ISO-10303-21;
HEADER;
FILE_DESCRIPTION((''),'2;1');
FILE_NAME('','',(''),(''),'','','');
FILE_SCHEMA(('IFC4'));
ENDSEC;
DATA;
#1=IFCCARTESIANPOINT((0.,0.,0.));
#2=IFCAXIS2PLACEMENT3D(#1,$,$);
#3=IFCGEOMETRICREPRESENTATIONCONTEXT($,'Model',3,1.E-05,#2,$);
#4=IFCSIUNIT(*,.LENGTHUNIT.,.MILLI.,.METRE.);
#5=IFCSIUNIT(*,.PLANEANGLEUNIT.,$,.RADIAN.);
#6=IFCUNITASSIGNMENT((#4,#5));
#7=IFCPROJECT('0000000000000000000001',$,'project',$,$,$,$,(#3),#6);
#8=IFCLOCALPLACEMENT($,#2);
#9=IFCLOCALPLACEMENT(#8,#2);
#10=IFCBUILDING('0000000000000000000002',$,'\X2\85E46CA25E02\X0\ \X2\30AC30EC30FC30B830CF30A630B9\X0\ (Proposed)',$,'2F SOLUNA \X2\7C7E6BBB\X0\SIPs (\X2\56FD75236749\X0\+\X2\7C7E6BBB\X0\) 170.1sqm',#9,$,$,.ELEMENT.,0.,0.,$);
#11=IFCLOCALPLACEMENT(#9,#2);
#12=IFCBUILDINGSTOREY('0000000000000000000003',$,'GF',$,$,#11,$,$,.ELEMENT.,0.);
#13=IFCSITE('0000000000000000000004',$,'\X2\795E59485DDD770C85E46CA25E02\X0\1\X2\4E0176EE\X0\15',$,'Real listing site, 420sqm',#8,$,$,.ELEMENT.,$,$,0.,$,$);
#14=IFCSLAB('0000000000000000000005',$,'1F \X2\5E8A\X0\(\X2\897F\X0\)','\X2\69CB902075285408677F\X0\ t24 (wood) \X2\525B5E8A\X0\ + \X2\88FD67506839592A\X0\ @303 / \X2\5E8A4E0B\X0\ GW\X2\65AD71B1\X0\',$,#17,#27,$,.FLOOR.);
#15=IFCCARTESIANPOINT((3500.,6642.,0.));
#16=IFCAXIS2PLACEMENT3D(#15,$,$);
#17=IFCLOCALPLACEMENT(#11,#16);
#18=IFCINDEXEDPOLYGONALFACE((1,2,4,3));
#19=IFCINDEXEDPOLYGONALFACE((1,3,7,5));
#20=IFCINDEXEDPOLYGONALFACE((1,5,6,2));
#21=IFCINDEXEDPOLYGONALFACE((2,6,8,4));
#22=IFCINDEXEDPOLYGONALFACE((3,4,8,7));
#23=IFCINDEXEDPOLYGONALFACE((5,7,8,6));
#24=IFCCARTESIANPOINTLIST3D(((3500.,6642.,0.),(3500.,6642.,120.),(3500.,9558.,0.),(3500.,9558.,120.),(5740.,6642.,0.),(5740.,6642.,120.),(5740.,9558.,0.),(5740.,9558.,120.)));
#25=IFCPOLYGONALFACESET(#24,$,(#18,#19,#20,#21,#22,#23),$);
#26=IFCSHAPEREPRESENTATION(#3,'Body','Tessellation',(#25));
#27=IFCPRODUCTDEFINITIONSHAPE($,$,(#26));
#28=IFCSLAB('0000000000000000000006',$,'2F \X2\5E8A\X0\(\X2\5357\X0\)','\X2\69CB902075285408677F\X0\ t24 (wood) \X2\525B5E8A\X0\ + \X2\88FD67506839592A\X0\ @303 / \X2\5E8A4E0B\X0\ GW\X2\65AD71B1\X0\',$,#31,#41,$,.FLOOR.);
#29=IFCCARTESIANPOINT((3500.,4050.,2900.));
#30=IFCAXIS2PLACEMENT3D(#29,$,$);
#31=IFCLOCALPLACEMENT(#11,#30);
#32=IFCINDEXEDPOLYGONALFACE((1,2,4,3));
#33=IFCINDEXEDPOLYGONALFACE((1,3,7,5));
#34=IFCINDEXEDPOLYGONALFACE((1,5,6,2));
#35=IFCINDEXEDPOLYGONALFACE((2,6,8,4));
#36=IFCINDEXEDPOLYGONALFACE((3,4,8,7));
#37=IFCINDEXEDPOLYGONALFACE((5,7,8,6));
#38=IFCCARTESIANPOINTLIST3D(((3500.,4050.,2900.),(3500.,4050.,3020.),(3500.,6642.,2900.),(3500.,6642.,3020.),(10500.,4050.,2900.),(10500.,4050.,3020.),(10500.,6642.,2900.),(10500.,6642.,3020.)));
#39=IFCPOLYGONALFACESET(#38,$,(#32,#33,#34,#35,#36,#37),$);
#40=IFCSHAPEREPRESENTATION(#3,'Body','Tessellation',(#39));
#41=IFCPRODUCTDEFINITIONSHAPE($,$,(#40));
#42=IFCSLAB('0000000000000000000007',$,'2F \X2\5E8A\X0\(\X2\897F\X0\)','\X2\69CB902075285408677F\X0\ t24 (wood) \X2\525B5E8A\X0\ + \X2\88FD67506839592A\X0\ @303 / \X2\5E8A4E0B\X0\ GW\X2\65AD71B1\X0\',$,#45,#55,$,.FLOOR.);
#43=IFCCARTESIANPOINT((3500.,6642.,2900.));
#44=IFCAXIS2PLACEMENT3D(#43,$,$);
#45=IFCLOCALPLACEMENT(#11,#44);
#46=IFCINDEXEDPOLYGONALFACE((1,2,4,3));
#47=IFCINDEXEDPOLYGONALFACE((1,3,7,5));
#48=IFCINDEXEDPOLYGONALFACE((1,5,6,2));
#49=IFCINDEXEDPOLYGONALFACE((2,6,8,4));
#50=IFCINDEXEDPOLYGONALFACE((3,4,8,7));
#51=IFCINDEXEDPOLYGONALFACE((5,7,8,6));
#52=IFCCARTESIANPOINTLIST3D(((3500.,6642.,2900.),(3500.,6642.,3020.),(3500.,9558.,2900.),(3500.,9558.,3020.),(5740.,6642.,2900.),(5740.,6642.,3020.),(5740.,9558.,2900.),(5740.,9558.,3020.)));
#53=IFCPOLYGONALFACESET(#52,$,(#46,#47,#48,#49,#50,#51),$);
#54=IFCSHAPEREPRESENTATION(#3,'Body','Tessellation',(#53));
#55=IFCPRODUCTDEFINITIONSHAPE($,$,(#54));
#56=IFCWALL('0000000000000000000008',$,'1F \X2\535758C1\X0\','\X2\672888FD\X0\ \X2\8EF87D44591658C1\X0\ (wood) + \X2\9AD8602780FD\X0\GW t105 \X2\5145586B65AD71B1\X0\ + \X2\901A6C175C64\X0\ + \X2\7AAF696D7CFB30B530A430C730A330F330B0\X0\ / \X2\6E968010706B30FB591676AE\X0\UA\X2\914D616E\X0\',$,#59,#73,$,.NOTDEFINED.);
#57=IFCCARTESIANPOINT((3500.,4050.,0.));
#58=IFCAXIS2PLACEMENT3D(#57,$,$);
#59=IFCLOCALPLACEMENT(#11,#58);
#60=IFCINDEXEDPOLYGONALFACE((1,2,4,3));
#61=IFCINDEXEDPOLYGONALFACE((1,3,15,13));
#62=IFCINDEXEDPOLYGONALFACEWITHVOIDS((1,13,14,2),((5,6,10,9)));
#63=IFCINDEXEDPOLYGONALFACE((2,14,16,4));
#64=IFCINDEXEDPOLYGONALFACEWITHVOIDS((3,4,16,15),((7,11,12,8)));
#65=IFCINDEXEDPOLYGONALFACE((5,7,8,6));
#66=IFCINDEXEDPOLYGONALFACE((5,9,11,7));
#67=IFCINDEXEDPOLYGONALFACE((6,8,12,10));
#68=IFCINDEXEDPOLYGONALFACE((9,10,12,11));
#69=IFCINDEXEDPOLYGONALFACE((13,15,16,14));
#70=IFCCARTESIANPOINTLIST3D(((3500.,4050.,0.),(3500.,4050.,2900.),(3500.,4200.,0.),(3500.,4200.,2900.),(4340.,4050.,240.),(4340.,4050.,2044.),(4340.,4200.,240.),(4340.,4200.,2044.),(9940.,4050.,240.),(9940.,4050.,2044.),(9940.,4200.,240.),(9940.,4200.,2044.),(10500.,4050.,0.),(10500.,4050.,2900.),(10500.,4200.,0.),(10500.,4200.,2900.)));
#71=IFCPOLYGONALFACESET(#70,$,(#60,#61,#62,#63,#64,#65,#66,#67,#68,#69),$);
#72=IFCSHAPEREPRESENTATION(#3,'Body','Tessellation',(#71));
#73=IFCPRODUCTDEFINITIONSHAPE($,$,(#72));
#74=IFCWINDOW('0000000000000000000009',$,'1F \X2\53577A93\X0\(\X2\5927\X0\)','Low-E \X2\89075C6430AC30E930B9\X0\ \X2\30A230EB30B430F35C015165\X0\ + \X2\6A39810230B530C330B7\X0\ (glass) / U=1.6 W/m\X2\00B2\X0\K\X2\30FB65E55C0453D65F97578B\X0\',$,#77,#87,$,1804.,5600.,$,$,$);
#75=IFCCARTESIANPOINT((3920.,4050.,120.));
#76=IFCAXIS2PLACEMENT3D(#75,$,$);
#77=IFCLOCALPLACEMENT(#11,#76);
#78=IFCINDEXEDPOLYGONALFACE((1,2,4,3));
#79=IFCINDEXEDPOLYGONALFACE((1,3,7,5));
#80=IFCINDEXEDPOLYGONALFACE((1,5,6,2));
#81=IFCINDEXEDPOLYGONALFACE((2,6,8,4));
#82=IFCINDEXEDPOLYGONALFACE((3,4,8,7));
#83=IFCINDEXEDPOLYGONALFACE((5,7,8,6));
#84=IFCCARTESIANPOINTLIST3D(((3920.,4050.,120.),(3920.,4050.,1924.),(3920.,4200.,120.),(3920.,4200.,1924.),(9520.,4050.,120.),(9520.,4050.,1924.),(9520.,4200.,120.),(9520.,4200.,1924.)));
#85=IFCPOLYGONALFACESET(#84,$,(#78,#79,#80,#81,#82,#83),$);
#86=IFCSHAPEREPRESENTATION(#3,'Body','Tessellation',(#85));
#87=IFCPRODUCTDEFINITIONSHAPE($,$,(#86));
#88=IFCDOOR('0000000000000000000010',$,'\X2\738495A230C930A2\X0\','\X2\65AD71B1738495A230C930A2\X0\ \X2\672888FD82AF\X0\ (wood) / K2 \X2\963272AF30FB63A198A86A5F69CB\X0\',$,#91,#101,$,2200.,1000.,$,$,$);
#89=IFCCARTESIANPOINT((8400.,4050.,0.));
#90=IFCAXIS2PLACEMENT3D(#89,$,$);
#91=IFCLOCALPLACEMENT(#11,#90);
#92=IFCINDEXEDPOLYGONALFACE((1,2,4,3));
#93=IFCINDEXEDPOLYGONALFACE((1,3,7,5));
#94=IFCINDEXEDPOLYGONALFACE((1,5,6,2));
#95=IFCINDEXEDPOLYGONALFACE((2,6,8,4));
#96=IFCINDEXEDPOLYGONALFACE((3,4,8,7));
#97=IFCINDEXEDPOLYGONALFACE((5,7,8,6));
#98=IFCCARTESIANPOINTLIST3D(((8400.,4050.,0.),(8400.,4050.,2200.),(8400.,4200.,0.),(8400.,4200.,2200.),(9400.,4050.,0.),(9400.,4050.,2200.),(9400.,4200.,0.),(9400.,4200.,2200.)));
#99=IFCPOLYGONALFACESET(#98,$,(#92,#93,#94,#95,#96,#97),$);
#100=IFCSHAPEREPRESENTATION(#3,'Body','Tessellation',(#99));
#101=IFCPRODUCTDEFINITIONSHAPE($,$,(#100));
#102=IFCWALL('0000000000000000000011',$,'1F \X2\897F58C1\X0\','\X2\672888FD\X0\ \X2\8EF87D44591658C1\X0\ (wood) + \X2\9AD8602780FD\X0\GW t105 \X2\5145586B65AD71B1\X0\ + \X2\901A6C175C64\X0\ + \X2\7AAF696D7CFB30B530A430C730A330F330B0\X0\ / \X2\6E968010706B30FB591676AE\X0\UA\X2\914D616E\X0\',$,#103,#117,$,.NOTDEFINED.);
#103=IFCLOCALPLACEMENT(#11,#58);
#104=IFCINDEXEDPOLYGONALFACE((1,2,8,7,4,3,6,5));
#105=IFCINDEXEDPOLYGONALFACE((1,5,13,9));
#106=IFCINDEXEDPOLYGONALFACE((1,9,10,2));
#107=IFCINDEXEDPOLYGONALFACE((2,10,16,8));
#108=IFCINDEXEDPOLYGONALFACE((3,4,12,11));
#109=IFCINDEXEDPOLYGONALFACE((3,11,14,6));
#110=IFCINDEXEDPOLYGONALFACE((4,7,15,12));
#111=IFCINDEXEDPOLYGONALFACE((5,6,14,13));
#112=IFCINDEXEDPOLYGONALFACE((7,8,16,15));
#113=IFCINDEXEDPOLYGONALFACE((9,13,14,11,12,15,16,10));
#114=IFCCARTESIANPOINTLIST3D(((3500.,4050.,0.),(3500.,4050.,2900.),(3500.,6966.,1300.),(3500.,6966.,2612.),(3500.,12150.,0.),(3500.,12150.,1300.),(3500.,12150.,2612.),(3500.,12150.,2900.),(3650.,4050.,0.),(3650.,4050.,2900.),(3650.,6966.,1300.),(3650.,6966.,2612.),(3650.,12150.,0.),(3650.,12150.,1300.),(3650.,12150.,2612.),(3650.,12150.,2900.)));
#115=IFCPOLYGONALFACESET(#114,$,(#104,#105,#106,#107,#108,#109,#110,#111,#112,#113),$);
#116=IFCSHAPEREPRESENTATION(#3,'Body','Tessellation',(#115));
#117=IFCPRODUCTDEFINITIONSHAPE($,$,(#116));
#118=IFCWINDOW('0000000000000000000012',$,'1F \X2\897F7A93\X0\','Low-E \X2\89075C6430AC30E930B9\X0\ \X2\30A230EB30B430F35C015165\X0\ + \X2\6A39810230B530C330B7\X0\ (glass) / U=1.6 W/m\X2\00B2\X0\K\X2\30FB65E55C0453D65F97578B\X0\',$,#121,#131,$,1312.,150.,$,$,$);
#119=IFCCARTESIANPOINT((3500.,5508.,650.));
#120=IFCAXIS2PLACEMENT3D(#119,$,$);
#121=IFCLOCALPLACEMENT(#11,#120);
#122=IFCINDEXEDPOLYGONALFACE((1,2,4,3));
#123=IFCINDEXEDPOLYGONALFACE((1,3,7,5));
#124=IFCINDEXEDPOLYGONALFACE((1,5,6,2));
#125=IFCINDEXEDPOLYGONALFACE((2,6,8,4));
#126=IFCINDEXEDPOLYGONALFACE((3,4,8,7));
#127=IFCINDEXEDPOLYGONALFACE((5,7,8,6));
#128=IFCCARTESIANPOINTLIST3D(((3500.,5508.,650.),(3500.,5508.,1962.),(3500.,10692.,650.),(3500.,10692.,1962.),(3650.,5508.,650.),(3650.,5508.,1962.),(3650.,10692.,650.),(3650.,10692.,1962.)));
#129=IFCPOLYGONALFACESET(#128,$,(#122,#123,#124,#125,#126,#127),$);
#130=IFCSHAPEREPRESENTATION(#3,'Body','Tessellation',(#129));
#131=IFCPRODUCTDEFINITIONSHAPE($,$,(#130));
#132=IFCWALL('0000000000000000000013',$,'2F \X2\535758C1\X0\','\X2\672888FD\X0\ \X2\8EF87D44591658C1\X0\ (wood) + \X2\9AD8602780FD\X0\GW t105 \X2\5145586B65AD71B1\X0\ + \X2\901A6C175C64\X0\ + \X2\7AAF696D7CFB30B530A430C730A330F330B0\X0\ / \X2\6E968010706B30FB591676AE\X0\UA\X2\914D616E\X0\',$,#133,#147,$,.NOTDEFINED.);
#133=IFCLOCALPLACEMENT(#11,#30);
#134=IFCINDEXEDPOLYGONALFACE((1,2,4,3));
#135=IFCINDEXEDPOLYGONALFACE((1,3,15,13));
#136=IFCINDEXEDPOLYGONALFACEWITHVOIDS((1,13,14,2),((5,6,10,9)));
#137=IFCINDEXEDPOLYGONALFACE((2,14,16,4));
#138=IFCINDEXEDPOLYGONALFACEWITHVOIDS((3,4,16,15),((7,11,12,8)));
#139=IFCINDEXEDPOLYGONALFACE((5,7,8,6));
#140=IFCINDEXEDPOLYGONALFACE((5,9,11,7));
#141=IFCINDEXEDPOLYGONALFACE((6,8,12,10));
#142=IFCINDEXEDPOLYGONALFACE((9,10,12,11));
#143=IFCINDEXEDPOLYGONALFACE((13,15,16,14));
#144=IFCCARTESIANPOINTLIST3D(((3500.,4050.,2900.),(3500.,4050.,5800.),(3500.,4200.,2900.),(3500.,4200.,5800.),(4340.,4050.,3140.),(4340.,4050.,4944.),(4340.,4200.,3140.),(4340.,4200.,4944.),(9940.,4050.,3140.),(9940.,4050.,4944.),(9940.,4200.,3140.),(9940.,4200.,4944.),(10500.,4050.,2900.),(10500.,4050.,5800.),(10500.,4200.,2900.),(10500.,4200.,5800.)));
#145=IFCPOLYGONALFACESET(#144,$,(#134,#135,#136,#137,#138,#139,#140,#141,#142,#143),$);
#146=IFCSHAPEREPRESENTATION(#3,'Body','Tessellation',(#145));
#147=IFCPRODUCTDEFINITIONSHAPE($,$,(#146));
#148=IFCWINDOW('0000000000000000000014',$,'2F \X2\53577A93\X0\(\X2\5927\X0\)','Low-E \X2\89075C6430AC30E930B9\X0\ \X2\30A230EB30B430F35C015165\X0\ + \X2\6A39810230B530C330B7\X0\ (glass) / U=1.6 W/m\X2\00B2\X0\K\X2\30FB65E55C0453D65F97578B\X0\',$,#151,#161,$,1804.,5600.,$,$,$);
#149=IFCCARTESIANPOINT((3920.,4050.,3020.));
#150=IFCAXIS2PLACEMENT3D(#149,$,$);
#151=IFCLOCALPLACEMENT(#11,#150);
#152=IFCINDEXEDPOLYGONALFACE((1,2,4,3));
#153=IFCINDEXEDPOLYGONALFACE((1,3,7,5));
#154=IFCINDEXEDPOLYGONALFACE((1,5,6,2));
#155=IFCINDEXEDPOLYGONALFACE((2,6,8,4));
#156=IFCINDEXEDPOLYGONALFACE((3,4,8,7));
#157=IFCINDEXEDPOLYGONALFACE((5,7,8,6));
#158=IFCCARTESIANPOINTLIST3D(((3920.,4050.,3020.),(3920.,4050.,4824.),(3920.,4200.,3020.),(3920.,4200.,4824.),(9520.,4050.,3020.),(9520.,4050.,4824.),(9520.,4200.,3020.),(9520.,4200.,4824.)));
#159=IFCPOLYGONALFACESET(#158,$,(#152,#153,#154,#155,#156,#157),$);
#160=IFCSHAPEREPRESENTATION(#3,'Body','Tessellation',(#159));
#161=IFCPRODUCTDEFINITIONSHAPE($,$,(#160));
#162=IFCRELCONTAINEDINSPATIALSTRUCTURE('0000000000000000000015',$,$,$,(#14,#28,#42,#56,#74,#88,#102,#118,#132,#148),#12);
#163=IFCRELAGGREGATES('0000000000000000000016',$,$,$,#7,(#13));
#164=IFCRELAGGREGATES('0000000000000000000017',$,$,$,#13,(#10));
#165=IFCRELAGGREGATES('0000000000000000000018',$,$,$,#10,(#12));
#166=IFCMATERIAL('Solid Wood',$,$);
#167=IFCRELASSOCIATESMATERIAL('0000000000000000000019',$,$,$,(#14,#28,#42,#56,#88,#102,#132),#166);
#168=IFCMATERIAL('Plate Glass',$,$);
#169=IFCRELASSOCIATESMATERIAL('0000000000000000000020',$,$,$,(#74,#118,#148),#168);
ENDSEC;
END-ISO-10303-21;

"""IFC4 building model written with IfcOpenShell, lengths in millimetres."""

from ifc_helpers import new_model, si_unit, frame, frame_2d, origin, place, context, project, spatial, rectangle, extrude, material, element, fill, save


model = new_model("IFC4")

# Units and contexts
model_context = context("Model", 3, precision=1e-05, world=origin())
ifc_project = project(units=[si_unit("LENGTHUNIT", "METRE", prefix="MILLI"), si_unit("PLANEANGLEUNIT", "RADIAN")], contexts=[model_context])

# Site, building, storey
site_placement = place(None, origin())
site = spatial("IfcSite", under=ifc_project, at=site_placement, Name="神奈川県藤沢市1丁目15", ObjectType="Real listing site, 420sqm", CompositionType="ELEMENT", RefElevation=0.0)
building_placement = place(site_placement, origin())
building = spatial("IfcBuilding", under=site, at=building_placement, Name="藤沢市 ガレージハウス (Proposed)", ObjectType="2F SOLUNA 籾殻SIPs (国産杉+籾殻) 170.1sqm", CompositionType="ELEMENT", ElevationOfRefHeight=0.0, ElevationOfTerrain=0.0)
storey_placement = place(building_placement, origin())
storey = spatial("IfcBuildingStorey", under=building, at=storey_placement, Name="GF", CompositionType="ELEMENT", Elevation=0.0)

# Slabs
ifc_material_1 = material(Name="Solid Wood")
slab_1_placement = place(storey_placement, frame((3500.0, 6642.0, 0.0)))
element("IfcSlab", 1, at=slab_1_placement, inside=storey, material=ifc_material_1, Name="1F 床(西)", Description="構造用合板 t24 (wood) 剛床 + 製材根太 @303 / 床下 GW断熱", PredefinedType="FLOOR", context=model_context, shape_type="SweptSolid", body=[
    extrude(rectangle(XDim=2240.0, YDim=2916.0, at=frame_2d((1120.0, 1458.0))), frame((3500.0, 6642.0, 0.0)), (0.0, 0.0, 1.0), 120.0),
])
slab_2_placement = place(storey_placement, frame((3500.0, 4050.0, 2900.0)))
element("IfcSlab", 2, at=slab_2_placement, inside=storey, material=ifc_material_1, Name="2F 床(南)", Description="構造用合板 t24 (wood) 剛床 + 製材根太 @303 / 床下 GW断熱", PredefinedType="FLOOR", context=model_context, shape_type="SweptSolid", body=[
    extrude(rectangle(XDim=7000.0, YDim=2592.0, at=frame_2d((3500.0, 1296.0))), frame((3500.0, 4050.0, 2900.0)), (0.0, 0.0, 1.0), 120.0),
])
slab_3_placement = place(storey_placement, frame((3500.0, 6642.0, 2900.0)))
element("IfcSlab", 3, at=slab_3_placement, inside=storey, material=ifc_material_1, Name="2F 床(西)", Description="構造用合板 t24 (wood) 剛床 + 製材根太 @303 / 床下 GW断熱", PredefinedType="FLOOR", context=model_context, shape_type="SweptSolid", body=[
    extrude(rectangle(XDim=2240.0, YDim=2916.0, at=frame_2d((1120.0, 1458.0))), frame((3500.0, 6642.0, 2900.0)), (0.0, 0.0, 1.0), 120.0),
])

# Wall, openings, window, door
wall_1_placement = place(storey_placement, frame((3500.0, 4050.0, 0.0)))
wall_1 = element("IfcWall", 4, at=wall_1_placement, inside=storey, material=ifc_material_1, Name="1F 南壁", Description="木製 軸組外壁 (wood) + 高性能GW t105 充填断熱 + 通気層 + 窯業系サイディング / 準耐火・外皮UA配慮", PredefinedType="NOTDEFINED", context=model_context, shape_type="SweptSolid", body=[
    extrude(rectangle(XDim=7000.0, YDim=150.0, at=frame_2d((3500.0, 75.0))), frame((3500.0, 4050.0, 0.0)), (0.0, 0.0, 1.0), 2900.0),
])
opening_1_placement = place(storey_placement, frame((3920.0, 4050.0, 120.0)))
opening_1 = element("IfcOpeningElement", 5, at=opening_1_placement, cuts=wall_1, PredefinedType="NOTDEFINED", context=model_context, shape_type="SweptSolid", body=[
    extrude(rectangle(XDim=5600.0, YDim=150.0, at=frame_2d((2800.0, 75.0))), frame((3920.0, 4050.0, 120.0)), (0.0, 0.0, 1.0), 1804.0),
])
opening_2_placement = place(storey_placement, frame((8400.0, 4050.0, 0.0)))
opening_2 = element("IfcOpeningElement", 6, at=opening_2_placement, cuts=wall_1, PredefinedType="NOTDEFINED", context=model_context, shape_type="SweptSolid", body=[
    extrude(rectangle(XDim=1000.0, YDim=150.0, at=frame_2d((500.0, 75.0))), frame((8400.0, 4050.0, 0.0)), (0.0, 0.0, 1.0), 2200.0),
])
ifc_material_2 = material(Name="Plate Glass")
window_1_placement = place(storey_placement, frame((3920.0, 4050.0, 120.0)))
window_1 = element("IfcWindow", 7, at=window_1_placement, inside=storey, material=ifc_material_2, Name="1F 南窓(大)", Description="Low-E 複層ガラス アルゴン封入 + 樹脂サッシ (glass) / U=1.6 W/m²K・日射取得型", OverallHeight=1804.0, OverallWidth=5600.0, context=model_context, shape_type="SweptSolid", body=[
    extrude(rectangle(XDim=5600.0, YDim=150.0, at=frame_2d((2800.0, 75.0))), frame((3920.0, 4050.0, 120.0)), (0.0, 0.0, 1.0), 1804.0),
])
fill(opening_1, window_1)
door_placement = place(storey_placement, frame((8400.0, 4050.0, 0.0)))
door = element("IfcDoor", 8, at=door_placement, inside=storey, material=ifc_material_1, Name="玄関ドア", Description="断熱玄関ドア 木製芯 (wood) / K2 防犯・採風機構", OverallHeight=2200.0, OverallWidth=1000.0, context=model_context, shape_type="SweptSolid", body=[
    extrude(rectangle(XDim=1000.0, YDim=150.0, at=frame_2d((500.0, 75.0))), frame((8400.0, 4050.0, 0.0)), (0.0, 0.0, 1.0), 2200.0),
])
fill(opening_2, door)

# Walls, openings, windows
wall_2_placement = place(storey_placement, frame((3500.0, 4050.0, 0.0)))
wall_2 = element("IfcWall", 9, at=wall_2_placement, inside=storey, material=ifc_material_1, Name="1F 西壁", Description="木製 軸組外壁 (wood) + 高性能GW t105 充填断熱 + 通気層 + 窯業系サイディング / 準耐火・外皮UA配慮", PredefinedType="NOTDEFINED", context=model_context, shape_type="SweptSolid", body=[
    extrude(rectangle(XDim=150.0, YDim=8100.0, at=frame_2d((75.0, 4050.0))), frame((3500.0, 4050.0, 0.0)), (0.0, 0.0, 1.0), 2900.0),
])
opening_3_placement = place(storey_placement, frame((3500.0, 5508.0, 650.0)))
opening_3 = element("IfcOpeningElement", 10, at=opening_3_placement, cuts=wall_2, PredefinedType="NOTDEFINED", context=model_context, shape_type="SweptSolid", body=[
    extrude(rectangle(XDim=150.0, YDim=5184.0, at=frame_2d((75.0, 2592.0))), frame((3500.0, 5508.0, 650.0)), (0.0, 0.0, 1.0), 1312.0),
])
window_2_placement = place(storey_placement, frame((3500.0, 5508.0, 650.0)))
window_2 = element("IfcWindow", 11, at=window_2_placement, inside=storey, material=ifc_material_2, Name="1F 西窓", Description="Low-E 複層ガラス アルゴン封入 + 樹脂サッシ (glass) / U=1.6 W/m²K・日射取得型", OverallHeight=1312.0, OverallWidth=150.0, context=model_context, shape_type="SweptSolid", body=[
    extrude(rectangle(XDim=150.0, YDim=5184.0, at=frame_2d((75.0, 2592.0))), frame((3500.0, 5508.0, 650.0)), (0.0, 0.0, 1.0), 1312.0),
])
fill(opening_3, window_2)
wall_3_placement = place(storey_placement, frame((3500.0, 4050.0, 2900.0)))
wall_3 = element("IfcWall", 12, at=wall_3_placement, inside=storey, material=ifc_material_1, Name="2F 南壁", Description="木製 軸組外壁 (wood) + 高性能GW t105 充填断熱 + 通気層 + 窯業系サイディング / 準耐火・外皮UA配慮", PredefinedType="NOTDEFINED", context=model_context, shape_type="SweptSolid", body=[
    extrude(rectangle(XDim=7000.0, YDim=150.0, at=frame_2d((3500.0, 75.0))), frame((3500.0, 4050.0, 2900.0)), (0.0, 0.0, 1.0), 2900.0),
])
opening_4_placement = place(storey_placement, frame((3920.0, 4050.0, 3020.0)))
opening_4 = element("IfcOpeningElement", 13, at=opening_4_placement, cuts=wall_3, PredefinedType="NOTDEFINED", context=model_context, shape_type="SweptSolid", body=[
    extrude(rectangle(XDim=5600.0, YDim=150.0, at=frame_2d((2800.0, 75.0))), frame((3920.0, 4050.0, 3020.0)), (0.0, 0.0, 1.0), 1804.0),
])
window_3_placement = place(storey_placement, frame((3920.0, 4050.0, 3020.0)))
window_3 = element("IfcWindow", 14, at=window_3_placement, inside=storey, material=ifc_material_2, Name="2F 南窓(大)", Description="Low-E 複層ガラス アルゴン封入 + 樹脂サッシ (glass) / U=1.6 W/m²K・日射取得型", OverallHeight=1804.0, OverallWidth=5600.0, context=model_context, shape_type="SweptSolid", body=[
    extrude(rectangle(XDim=5600.0, YDim=150.0, at=frame_2d((2800.0, 75.0))), frame((3920.0, 4050.0, 3020.0)), (0.0, 0.0, 1.0), 1804.0),
])
fill(opening_4, window_3)

save(model, "model.ifc")
